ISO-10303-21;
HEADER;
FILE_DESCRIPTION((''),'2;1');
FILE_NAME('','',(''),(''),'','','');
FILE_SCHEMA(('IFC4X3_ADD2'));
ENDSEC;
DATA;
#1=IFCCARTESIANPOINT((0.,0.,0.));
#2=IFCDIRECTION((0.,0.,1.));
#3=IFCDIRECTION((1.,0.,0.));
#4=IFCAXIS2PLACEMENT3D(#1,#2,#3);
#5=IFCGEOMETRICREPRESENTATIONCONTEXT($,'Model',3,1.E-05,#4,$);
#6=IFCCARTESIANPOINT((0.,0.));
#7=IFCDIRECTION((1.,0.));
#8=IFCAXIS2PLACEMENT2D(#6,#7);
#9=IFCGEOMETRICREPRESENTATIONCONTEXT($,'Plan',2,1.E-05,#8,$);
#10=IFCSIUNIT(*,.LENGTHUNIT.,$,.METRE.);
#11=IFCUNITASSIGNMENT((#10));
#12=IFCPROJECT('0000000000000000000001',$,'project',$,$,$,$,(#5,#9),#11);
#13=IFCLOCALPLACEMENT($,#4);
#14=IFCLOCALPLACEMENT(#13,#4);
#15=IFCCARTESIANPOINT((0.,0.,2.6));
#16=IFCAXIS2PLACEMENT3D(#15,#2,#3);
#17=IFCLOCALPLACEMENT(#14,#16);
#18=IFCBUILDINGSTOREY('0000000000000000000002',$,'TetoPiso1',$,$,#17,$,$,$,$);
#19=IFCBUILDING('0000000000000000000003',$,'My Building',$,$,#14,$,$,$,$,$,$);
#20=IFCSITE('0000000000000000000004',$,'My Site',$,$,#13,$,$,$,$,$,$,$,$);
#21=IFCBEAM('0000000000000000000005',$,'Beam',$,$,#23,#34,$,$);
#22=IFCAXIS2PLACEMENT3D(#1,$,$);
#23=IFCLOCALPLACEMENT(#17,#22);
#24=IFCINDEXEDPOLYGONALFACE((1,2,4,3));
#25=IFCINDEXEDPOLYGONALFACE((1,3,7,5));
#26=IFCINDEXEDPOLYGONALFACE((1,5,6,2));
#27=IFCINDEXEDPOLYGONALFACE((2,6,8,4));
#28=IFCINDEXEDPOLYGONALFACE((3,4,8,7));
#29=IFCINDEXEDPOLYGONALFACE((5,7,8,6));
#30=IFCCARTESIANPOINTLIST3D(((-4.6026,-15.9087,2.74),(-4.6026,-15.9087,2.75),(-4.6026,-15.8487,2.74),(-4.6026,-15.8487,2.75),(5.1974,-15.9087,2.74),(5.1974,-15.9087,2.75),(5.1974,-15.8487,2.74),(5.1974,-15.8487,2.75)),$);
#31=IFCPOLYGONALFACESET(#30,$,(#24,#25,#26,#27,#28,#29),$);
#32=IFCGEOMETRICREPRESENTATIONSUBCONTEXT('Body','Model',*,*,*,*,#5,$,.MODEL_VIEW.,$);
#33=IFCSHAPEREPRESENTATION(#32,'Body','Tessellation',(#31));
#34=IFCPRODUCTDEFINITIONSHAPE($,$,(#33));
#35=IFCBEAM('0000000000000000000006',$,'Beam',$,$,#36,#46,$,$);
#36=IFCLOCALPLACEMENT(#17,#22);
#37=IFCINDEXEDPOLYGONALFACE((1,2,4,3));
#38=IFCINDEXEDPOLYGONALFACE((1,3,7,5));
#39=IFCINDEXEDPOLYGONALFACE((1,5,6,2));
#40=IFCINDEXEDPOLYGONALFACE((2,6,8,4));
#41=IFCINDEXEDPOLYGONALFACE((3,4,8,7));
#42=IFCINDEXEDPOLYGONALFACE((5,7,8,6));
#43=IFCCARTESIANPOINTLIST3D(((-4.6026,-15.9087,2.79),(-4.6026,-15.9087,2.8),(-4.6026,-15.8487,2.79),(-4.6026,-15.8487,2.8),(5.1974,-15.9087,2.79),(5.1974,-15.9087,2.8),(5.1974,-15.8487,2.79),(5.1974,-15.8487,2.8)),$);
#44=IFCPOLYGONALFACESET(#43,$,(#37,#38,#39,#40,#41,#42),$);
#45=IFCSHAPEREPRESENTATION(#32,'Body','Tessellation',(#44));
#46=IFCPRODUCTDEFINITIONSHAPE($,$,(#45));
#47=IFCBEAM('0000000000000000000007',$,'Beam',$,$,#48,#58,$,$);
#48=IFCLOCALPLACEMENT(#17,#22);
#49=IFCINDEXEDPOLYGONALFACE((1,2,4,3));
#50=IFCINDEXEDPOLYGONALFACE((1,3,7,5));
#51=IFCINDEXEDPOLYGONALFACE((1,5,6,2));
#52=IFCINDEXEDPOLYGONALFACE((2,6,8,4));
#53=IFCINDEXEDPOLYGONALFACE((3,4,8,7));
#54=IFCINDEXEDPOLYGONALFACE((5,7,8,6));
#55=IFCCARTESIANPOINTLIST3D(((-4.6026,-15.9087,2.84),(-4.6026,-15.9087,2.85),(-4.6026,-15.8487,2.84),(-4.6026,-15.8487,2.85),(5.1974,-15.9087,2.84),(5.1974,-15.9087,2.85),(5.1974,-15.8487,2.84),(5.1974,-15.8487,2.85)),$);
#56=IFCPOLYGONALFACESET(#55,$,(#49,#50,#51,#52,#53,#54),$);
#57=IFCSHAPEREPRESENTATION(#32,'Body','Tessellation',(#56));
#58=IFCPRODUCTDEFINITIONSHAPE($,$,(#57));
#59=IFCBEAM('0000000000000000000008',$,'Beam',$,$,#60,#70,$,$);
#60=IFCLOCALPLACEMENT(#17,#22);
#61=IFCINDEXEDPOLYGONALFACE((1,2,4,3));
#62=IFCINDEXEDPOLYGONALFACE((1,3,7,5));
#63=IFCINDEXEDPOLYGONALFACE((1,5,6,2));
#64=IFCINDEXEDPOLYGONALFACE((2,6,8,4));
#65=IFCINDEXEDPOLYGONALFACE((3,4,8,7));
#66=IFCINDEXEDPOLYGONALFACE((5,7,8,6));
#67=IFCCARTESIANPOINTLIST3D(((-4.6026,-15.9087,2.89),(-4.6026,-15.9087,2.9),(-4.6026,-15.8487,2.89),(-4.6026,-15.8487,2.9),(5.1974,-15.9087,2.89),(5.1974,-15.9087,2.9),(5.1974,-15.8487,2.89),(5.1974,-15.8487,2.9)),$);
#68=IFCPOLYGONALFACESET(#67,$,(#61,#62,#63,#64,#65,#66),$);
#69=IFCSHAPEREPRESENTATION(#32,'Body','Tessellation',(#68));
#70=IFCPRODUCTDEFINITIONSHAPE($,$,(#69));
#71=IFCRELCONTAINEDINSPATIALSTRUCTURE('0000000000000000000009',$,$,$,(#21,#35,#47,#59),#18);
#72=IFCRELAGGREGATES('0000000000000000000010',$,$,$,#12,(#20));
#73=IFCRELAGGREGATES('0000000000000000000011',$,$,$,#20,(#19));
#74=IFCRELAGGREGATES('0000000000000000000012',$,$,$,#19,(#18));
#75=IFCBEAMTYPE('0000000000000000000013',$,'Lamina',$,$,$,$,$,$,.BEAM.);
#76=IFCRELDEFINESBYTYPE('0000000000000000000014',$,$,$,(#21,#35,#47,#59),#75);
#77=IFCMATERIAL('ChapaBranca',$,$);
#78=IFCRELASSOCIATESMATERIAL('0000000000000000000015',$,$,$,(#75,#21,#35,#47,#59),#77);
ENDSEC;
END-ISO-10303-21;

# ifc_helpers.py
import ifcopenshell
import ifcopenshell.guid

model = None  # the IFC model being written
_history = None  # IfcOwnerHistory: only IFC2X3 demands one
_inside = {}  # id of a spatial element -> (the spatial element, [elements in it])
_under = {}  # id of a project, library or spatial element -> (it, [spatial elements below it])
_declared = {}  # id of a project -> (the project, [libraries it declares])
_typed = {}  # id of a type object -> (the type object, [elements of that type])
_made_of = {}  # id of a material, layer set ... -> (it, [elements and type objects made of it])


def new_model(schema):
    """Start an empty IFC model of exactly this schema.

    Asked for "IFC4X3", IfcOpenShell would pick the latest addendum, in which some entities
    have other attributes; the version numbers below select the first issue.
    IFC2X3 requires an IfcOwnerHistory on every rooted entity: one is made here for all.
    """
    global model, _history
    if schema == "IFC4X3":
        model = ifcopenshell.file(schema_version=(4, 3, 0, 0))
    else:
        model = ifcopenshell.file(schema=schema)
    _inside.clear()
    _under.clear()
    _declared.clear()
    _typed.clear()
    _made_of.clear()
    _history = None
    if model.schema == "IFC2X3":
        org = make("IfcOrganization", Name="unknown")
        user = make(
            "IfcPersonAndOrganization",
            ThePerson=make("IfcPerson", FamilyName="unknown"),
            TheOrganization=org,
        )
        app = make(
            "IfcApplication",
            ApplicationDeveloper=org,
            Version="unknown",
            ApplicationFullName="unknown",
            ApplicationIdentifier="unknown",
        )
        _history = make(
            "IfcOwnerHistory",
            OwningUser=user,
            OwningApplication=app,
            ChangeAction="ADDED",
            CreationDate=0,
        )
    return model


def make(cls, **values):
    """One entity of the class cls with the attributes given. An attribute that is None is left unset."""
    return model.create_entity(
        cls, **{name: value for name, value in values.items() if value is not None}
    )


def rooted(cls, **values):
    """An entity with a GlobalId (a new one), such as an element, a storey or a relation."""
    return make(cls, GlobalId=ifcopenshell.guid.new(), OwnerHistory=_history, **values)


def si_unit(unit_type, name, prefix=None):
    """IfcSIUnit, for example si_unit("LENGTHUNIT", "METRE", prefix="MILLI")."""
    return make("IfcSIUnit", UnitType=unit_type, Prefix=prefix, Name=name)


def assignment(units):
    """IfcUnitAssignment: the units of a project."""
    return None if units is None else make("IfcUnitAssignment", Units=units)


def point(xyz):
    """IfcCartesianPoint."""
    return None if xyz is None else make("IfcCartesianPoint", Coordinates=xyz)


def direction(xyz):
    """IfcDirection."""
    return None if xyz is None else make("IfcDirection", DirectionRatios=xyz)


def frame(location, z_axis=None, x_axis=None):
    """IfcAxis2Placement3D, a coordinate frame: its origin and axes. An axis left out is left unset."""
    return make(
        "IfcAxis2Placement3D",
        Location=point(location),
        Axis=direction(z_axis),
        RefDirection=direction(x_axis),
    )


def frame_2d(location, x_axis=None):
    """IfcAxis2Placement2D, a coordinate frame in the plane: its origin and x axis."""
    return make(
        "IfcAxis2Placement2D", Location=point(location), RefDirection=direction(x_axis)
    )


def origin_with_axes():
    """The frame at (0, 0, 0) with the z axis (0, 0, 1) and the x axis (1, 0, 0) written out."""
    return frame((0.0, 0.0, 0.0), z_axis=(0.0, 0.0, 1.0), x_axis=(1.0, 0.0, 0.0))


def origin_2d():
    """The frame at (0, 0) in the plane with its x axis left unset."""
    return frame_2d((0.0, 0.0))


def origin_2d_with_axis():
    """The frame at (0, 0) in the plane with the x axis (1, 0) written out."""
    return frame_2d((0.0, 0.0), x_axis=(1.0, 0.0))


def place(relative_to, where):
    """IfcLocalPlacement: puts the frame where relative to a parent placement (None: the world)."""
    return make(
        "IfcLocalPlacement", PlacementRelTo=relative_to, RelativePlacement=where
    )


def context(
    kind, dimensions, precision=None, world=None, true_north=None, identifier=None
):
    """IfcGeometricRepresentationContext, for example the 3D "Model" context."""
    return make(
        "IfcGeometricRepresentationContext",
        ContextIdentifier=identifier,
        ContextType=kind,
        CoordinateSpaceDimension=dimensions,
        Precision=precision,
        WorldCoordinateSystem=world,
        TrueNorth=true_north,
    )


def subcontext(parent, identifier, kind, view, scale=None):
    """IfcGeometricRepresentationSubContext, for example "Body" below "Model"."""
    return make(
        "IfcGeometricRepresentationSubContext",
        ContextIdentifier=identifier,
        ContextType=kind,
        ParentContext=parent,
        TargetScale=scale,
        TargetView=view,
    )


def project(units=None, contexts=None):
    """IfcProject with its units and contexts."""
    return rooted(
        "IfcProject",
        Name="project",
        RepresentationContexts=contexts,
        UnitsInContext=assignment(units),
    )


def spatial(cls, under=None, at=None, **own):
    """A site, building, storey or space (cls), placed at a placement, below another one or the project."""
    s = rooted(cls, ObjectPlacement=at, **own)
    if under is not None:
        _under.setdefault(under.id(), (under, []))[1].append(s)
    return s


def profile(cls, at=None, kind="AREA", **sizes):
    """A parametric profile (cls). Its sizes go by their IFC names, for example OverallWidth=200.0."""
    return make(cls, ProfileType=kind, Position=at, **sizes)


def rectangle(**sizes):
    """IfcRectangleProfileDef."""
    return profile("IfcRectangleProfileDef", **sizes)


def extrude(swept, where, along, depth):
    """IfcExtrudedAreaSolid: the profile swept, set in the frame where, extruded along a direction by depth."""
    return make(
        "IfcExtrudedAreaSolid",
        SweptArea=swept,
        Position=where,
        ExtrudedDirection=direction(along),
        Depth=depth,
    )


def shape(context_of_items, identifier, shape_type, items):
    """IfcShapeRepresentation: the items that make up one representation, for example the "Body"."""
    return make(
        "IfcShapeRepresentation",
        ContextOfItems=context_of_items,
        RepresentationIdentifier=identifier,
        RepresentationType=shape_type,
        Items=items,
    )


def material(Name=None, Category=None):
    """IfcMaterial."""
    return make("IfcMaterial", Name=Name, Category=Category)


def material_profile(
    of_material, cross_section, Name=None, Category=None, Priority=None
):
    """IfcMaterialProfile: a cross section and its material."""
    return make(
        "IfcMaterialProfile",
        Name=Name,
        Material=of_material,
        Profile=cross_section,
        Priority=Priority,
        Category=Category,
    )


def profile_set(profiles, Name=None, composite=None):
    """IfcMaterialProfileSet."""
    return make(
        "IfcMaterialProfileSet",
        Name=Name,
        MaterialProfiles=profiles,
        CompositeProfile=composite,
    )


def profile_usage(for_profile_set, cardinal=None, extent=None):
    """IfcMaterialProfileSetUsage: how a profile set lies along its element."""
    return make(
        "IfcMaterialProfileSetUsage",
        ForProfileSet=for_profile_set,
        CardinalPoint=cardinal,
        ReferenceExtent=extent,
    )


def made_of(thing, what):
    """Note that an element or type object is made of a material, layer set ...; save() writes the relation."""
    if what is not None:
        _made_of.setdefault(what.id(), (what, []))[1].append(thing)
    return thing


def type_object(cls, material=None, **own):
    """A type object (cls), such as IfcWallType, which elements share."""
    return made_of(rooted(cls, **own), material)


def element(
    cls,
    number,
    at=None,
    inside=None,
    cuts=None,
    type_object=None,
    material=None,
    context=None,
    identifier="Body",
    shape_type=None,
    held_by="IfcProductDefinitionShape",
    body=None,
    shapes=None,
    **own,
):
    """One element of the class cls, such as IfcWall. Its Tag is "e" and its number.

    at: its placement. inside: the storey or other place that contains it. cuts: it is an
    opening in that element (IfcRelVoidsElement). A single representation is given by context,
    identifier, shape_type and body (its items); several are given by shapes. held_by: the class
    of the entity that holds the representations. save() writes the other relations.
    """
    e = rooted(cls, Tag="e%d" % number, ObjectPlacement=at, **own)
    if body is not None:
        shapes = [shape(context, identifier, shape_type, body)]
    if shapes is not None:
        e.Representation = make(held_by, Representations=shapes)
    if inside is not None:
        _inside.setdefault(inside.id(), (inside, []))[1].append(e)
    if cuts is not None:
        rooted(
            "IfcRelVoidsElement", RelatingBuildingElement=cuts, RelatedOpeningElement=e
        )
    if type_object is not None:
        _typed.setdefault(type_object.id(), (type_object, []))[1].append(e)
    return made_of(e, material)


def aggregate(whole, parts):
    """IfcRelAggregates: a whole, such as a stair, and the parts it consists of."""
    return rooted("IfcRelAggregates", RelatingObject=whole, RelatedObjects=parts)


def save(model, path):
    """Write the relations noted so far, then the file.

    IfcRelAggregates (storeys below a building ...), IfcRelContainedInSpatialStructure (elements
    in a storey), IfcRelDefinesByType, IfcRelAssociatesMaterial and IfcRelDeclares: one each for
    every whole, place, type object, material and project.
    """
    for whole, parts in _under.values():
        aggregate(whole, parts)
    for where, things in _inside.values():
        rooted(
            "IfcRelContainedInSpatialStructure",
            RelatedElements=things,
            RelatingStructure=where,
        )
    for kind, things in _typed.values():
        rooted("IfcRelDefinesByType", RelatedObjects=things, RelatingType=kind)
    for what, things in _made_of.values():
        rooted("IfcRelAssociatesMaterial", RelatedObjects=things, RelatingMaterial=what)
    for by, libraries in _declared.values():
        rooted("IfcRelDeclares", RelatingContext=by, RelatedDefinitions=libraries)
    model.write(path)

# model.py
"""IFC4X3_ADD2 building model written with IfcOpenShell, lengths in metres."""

from ifc_helpers import new_model, si_unit, frame, origin_with_axes, origin_2d, origin_2d_with_axis, place, context, subcontext, project, spatial, rectangle, extrude, material, material_profile, profile_set, profile_usage, type_object, element, save


model = new_model("IFC4X3_ADD2")

# Units and contexts
model_context = context("Model", 3, precision=1e-05, world=origin_with_axes())
plan_context = context("Plan", 2, precision=1e-05, world=origin_2d_with_axis())
body_context = subcontext(model_context, "Body", "Model", "MODEL_VIEW")
ifc_project = project(units=[si_unit("LENGTHUNIT", "METRE")], contexts=[model_context, plan_context])

# Site, building, storey
site_placement = place(None, origin_with_axes())
site = spatial("IfcSite", under=ifc_project, at=site_placement, Name="My Site")
building_placement = place(site_placement, origin_with_axes())
building = spatial("IfcBuilding", under=site, at=building_placement, Name="My Building")
storey_placement = place(building_placement, frame((0.0, 0.0, 2.6), z_axis=(0.0, 0.0, 1.0), x_axis=(1.0, 0.0, 0.0)))
storey = spatial("IfcBuildingStorey", under=building, at=storey_placement, Name="TetoPiso1")

# Beams
ifc_material = material(Name="ChapaBranca")
ifc_material_profile = material_profile(ifc_material, rectangle(XDim=0.06, YDim=0.01, at=origin_2d()))
ifc_profile_set = profile_set([ifc_material_profile])
beam_type = type_object("IfcBeamType", Name="Lamina", PredefinedType="BEAM", material=ifc_profile_set)
ifc_profile_usage_1 = profile_usage(ifc_profile_set, cardinal=5)
beam_1_placement = place(storey_placement, frame((-4.6026, -15.8787, 2.745), z_axis=(1.0, 0.0, 0.0), x_axis=(0.0, 1.0, 0.0)))
element("IfcBeam", 1, at=beam_1_placement, inside=storey, type_object=beam_type, material=ifc_profile_usage_1, Name="Beam", context=body_context, shape_type="SweptSolid", body=[
    extrude(rectangle(XDim=0.06, YDim=0.01, at=origin_2d()), origin_with_axes(), (0.0, 0.0, 1.0), 9.8),
])
ifc_profile_usage_2 = profile_usage(ifc_profile_set, cardinal=5)
beam_2_placement = place(storey_placement, frame((-4.6026, -15.8787, 2.795), z_axis=(1.0, 0.0, 0.0), x_axis=(0.0, 1.0, 0.0)))
element("IfcBeam", 2, at=beam_2_placement, inside=storey, type_object=beam_type, material=ifc_profile_usage_2, Name="Beam", context=body_context, shape_type="SweptSolid", body=[
    extrude(rectangle(XDim=0.06, YDim=0.01, at=origin_2d()), origin_with_axes(), (0.0, 0.0, 1.0), 9.8),
])
ifc_profile_usage_3 = profile_usage(ifc_profile_set, cardinal=5)
beam_3_placement = place(storey_placement, frame((-4.6026, -15.8787, 2.845), z_axis=(1.0, 0.0, 0.0), x_axis=(0.0, 1.0, 0.0)))
element("IfcBeam", 3, at=beam_3_placement, inside=storey, type_object=beam_type, material=ifc_profile_usage_3, Name="Beam", context=body_context, shape_type="SweptSolid", body=[
    extrude(rectangle(XDim=0.06, YDim=0.01, at=origin_2d()), origin_with_axes(), (0.0, 0.0, 1.0), 9.8),
])
ifc_profile_usage_4 = profile_usage(ifc_profile_set, cardinal=5)
beam_4_placement = place(storey_placement, frame((-4.6026, -15.8787, 2.895), z_axis=(1.0, 0.0, 0.0), x_axis=(0.0, 1.0, 0.0)))
element("IfcBeam", 4, at=beam_4_placement, inside=storey, type_object=beam_type, material=ifc_profile_usage_4, Name="Beam", context=body_context, shape_type="SweptSolid", body=[
    extrude(rectangle(XDim=0.06, YDim=0.01, at=origin_2d()), origin_with_axes(), (0.0, 0.0, 1.0), 9.8),
])

save(model, "model.ifc")
